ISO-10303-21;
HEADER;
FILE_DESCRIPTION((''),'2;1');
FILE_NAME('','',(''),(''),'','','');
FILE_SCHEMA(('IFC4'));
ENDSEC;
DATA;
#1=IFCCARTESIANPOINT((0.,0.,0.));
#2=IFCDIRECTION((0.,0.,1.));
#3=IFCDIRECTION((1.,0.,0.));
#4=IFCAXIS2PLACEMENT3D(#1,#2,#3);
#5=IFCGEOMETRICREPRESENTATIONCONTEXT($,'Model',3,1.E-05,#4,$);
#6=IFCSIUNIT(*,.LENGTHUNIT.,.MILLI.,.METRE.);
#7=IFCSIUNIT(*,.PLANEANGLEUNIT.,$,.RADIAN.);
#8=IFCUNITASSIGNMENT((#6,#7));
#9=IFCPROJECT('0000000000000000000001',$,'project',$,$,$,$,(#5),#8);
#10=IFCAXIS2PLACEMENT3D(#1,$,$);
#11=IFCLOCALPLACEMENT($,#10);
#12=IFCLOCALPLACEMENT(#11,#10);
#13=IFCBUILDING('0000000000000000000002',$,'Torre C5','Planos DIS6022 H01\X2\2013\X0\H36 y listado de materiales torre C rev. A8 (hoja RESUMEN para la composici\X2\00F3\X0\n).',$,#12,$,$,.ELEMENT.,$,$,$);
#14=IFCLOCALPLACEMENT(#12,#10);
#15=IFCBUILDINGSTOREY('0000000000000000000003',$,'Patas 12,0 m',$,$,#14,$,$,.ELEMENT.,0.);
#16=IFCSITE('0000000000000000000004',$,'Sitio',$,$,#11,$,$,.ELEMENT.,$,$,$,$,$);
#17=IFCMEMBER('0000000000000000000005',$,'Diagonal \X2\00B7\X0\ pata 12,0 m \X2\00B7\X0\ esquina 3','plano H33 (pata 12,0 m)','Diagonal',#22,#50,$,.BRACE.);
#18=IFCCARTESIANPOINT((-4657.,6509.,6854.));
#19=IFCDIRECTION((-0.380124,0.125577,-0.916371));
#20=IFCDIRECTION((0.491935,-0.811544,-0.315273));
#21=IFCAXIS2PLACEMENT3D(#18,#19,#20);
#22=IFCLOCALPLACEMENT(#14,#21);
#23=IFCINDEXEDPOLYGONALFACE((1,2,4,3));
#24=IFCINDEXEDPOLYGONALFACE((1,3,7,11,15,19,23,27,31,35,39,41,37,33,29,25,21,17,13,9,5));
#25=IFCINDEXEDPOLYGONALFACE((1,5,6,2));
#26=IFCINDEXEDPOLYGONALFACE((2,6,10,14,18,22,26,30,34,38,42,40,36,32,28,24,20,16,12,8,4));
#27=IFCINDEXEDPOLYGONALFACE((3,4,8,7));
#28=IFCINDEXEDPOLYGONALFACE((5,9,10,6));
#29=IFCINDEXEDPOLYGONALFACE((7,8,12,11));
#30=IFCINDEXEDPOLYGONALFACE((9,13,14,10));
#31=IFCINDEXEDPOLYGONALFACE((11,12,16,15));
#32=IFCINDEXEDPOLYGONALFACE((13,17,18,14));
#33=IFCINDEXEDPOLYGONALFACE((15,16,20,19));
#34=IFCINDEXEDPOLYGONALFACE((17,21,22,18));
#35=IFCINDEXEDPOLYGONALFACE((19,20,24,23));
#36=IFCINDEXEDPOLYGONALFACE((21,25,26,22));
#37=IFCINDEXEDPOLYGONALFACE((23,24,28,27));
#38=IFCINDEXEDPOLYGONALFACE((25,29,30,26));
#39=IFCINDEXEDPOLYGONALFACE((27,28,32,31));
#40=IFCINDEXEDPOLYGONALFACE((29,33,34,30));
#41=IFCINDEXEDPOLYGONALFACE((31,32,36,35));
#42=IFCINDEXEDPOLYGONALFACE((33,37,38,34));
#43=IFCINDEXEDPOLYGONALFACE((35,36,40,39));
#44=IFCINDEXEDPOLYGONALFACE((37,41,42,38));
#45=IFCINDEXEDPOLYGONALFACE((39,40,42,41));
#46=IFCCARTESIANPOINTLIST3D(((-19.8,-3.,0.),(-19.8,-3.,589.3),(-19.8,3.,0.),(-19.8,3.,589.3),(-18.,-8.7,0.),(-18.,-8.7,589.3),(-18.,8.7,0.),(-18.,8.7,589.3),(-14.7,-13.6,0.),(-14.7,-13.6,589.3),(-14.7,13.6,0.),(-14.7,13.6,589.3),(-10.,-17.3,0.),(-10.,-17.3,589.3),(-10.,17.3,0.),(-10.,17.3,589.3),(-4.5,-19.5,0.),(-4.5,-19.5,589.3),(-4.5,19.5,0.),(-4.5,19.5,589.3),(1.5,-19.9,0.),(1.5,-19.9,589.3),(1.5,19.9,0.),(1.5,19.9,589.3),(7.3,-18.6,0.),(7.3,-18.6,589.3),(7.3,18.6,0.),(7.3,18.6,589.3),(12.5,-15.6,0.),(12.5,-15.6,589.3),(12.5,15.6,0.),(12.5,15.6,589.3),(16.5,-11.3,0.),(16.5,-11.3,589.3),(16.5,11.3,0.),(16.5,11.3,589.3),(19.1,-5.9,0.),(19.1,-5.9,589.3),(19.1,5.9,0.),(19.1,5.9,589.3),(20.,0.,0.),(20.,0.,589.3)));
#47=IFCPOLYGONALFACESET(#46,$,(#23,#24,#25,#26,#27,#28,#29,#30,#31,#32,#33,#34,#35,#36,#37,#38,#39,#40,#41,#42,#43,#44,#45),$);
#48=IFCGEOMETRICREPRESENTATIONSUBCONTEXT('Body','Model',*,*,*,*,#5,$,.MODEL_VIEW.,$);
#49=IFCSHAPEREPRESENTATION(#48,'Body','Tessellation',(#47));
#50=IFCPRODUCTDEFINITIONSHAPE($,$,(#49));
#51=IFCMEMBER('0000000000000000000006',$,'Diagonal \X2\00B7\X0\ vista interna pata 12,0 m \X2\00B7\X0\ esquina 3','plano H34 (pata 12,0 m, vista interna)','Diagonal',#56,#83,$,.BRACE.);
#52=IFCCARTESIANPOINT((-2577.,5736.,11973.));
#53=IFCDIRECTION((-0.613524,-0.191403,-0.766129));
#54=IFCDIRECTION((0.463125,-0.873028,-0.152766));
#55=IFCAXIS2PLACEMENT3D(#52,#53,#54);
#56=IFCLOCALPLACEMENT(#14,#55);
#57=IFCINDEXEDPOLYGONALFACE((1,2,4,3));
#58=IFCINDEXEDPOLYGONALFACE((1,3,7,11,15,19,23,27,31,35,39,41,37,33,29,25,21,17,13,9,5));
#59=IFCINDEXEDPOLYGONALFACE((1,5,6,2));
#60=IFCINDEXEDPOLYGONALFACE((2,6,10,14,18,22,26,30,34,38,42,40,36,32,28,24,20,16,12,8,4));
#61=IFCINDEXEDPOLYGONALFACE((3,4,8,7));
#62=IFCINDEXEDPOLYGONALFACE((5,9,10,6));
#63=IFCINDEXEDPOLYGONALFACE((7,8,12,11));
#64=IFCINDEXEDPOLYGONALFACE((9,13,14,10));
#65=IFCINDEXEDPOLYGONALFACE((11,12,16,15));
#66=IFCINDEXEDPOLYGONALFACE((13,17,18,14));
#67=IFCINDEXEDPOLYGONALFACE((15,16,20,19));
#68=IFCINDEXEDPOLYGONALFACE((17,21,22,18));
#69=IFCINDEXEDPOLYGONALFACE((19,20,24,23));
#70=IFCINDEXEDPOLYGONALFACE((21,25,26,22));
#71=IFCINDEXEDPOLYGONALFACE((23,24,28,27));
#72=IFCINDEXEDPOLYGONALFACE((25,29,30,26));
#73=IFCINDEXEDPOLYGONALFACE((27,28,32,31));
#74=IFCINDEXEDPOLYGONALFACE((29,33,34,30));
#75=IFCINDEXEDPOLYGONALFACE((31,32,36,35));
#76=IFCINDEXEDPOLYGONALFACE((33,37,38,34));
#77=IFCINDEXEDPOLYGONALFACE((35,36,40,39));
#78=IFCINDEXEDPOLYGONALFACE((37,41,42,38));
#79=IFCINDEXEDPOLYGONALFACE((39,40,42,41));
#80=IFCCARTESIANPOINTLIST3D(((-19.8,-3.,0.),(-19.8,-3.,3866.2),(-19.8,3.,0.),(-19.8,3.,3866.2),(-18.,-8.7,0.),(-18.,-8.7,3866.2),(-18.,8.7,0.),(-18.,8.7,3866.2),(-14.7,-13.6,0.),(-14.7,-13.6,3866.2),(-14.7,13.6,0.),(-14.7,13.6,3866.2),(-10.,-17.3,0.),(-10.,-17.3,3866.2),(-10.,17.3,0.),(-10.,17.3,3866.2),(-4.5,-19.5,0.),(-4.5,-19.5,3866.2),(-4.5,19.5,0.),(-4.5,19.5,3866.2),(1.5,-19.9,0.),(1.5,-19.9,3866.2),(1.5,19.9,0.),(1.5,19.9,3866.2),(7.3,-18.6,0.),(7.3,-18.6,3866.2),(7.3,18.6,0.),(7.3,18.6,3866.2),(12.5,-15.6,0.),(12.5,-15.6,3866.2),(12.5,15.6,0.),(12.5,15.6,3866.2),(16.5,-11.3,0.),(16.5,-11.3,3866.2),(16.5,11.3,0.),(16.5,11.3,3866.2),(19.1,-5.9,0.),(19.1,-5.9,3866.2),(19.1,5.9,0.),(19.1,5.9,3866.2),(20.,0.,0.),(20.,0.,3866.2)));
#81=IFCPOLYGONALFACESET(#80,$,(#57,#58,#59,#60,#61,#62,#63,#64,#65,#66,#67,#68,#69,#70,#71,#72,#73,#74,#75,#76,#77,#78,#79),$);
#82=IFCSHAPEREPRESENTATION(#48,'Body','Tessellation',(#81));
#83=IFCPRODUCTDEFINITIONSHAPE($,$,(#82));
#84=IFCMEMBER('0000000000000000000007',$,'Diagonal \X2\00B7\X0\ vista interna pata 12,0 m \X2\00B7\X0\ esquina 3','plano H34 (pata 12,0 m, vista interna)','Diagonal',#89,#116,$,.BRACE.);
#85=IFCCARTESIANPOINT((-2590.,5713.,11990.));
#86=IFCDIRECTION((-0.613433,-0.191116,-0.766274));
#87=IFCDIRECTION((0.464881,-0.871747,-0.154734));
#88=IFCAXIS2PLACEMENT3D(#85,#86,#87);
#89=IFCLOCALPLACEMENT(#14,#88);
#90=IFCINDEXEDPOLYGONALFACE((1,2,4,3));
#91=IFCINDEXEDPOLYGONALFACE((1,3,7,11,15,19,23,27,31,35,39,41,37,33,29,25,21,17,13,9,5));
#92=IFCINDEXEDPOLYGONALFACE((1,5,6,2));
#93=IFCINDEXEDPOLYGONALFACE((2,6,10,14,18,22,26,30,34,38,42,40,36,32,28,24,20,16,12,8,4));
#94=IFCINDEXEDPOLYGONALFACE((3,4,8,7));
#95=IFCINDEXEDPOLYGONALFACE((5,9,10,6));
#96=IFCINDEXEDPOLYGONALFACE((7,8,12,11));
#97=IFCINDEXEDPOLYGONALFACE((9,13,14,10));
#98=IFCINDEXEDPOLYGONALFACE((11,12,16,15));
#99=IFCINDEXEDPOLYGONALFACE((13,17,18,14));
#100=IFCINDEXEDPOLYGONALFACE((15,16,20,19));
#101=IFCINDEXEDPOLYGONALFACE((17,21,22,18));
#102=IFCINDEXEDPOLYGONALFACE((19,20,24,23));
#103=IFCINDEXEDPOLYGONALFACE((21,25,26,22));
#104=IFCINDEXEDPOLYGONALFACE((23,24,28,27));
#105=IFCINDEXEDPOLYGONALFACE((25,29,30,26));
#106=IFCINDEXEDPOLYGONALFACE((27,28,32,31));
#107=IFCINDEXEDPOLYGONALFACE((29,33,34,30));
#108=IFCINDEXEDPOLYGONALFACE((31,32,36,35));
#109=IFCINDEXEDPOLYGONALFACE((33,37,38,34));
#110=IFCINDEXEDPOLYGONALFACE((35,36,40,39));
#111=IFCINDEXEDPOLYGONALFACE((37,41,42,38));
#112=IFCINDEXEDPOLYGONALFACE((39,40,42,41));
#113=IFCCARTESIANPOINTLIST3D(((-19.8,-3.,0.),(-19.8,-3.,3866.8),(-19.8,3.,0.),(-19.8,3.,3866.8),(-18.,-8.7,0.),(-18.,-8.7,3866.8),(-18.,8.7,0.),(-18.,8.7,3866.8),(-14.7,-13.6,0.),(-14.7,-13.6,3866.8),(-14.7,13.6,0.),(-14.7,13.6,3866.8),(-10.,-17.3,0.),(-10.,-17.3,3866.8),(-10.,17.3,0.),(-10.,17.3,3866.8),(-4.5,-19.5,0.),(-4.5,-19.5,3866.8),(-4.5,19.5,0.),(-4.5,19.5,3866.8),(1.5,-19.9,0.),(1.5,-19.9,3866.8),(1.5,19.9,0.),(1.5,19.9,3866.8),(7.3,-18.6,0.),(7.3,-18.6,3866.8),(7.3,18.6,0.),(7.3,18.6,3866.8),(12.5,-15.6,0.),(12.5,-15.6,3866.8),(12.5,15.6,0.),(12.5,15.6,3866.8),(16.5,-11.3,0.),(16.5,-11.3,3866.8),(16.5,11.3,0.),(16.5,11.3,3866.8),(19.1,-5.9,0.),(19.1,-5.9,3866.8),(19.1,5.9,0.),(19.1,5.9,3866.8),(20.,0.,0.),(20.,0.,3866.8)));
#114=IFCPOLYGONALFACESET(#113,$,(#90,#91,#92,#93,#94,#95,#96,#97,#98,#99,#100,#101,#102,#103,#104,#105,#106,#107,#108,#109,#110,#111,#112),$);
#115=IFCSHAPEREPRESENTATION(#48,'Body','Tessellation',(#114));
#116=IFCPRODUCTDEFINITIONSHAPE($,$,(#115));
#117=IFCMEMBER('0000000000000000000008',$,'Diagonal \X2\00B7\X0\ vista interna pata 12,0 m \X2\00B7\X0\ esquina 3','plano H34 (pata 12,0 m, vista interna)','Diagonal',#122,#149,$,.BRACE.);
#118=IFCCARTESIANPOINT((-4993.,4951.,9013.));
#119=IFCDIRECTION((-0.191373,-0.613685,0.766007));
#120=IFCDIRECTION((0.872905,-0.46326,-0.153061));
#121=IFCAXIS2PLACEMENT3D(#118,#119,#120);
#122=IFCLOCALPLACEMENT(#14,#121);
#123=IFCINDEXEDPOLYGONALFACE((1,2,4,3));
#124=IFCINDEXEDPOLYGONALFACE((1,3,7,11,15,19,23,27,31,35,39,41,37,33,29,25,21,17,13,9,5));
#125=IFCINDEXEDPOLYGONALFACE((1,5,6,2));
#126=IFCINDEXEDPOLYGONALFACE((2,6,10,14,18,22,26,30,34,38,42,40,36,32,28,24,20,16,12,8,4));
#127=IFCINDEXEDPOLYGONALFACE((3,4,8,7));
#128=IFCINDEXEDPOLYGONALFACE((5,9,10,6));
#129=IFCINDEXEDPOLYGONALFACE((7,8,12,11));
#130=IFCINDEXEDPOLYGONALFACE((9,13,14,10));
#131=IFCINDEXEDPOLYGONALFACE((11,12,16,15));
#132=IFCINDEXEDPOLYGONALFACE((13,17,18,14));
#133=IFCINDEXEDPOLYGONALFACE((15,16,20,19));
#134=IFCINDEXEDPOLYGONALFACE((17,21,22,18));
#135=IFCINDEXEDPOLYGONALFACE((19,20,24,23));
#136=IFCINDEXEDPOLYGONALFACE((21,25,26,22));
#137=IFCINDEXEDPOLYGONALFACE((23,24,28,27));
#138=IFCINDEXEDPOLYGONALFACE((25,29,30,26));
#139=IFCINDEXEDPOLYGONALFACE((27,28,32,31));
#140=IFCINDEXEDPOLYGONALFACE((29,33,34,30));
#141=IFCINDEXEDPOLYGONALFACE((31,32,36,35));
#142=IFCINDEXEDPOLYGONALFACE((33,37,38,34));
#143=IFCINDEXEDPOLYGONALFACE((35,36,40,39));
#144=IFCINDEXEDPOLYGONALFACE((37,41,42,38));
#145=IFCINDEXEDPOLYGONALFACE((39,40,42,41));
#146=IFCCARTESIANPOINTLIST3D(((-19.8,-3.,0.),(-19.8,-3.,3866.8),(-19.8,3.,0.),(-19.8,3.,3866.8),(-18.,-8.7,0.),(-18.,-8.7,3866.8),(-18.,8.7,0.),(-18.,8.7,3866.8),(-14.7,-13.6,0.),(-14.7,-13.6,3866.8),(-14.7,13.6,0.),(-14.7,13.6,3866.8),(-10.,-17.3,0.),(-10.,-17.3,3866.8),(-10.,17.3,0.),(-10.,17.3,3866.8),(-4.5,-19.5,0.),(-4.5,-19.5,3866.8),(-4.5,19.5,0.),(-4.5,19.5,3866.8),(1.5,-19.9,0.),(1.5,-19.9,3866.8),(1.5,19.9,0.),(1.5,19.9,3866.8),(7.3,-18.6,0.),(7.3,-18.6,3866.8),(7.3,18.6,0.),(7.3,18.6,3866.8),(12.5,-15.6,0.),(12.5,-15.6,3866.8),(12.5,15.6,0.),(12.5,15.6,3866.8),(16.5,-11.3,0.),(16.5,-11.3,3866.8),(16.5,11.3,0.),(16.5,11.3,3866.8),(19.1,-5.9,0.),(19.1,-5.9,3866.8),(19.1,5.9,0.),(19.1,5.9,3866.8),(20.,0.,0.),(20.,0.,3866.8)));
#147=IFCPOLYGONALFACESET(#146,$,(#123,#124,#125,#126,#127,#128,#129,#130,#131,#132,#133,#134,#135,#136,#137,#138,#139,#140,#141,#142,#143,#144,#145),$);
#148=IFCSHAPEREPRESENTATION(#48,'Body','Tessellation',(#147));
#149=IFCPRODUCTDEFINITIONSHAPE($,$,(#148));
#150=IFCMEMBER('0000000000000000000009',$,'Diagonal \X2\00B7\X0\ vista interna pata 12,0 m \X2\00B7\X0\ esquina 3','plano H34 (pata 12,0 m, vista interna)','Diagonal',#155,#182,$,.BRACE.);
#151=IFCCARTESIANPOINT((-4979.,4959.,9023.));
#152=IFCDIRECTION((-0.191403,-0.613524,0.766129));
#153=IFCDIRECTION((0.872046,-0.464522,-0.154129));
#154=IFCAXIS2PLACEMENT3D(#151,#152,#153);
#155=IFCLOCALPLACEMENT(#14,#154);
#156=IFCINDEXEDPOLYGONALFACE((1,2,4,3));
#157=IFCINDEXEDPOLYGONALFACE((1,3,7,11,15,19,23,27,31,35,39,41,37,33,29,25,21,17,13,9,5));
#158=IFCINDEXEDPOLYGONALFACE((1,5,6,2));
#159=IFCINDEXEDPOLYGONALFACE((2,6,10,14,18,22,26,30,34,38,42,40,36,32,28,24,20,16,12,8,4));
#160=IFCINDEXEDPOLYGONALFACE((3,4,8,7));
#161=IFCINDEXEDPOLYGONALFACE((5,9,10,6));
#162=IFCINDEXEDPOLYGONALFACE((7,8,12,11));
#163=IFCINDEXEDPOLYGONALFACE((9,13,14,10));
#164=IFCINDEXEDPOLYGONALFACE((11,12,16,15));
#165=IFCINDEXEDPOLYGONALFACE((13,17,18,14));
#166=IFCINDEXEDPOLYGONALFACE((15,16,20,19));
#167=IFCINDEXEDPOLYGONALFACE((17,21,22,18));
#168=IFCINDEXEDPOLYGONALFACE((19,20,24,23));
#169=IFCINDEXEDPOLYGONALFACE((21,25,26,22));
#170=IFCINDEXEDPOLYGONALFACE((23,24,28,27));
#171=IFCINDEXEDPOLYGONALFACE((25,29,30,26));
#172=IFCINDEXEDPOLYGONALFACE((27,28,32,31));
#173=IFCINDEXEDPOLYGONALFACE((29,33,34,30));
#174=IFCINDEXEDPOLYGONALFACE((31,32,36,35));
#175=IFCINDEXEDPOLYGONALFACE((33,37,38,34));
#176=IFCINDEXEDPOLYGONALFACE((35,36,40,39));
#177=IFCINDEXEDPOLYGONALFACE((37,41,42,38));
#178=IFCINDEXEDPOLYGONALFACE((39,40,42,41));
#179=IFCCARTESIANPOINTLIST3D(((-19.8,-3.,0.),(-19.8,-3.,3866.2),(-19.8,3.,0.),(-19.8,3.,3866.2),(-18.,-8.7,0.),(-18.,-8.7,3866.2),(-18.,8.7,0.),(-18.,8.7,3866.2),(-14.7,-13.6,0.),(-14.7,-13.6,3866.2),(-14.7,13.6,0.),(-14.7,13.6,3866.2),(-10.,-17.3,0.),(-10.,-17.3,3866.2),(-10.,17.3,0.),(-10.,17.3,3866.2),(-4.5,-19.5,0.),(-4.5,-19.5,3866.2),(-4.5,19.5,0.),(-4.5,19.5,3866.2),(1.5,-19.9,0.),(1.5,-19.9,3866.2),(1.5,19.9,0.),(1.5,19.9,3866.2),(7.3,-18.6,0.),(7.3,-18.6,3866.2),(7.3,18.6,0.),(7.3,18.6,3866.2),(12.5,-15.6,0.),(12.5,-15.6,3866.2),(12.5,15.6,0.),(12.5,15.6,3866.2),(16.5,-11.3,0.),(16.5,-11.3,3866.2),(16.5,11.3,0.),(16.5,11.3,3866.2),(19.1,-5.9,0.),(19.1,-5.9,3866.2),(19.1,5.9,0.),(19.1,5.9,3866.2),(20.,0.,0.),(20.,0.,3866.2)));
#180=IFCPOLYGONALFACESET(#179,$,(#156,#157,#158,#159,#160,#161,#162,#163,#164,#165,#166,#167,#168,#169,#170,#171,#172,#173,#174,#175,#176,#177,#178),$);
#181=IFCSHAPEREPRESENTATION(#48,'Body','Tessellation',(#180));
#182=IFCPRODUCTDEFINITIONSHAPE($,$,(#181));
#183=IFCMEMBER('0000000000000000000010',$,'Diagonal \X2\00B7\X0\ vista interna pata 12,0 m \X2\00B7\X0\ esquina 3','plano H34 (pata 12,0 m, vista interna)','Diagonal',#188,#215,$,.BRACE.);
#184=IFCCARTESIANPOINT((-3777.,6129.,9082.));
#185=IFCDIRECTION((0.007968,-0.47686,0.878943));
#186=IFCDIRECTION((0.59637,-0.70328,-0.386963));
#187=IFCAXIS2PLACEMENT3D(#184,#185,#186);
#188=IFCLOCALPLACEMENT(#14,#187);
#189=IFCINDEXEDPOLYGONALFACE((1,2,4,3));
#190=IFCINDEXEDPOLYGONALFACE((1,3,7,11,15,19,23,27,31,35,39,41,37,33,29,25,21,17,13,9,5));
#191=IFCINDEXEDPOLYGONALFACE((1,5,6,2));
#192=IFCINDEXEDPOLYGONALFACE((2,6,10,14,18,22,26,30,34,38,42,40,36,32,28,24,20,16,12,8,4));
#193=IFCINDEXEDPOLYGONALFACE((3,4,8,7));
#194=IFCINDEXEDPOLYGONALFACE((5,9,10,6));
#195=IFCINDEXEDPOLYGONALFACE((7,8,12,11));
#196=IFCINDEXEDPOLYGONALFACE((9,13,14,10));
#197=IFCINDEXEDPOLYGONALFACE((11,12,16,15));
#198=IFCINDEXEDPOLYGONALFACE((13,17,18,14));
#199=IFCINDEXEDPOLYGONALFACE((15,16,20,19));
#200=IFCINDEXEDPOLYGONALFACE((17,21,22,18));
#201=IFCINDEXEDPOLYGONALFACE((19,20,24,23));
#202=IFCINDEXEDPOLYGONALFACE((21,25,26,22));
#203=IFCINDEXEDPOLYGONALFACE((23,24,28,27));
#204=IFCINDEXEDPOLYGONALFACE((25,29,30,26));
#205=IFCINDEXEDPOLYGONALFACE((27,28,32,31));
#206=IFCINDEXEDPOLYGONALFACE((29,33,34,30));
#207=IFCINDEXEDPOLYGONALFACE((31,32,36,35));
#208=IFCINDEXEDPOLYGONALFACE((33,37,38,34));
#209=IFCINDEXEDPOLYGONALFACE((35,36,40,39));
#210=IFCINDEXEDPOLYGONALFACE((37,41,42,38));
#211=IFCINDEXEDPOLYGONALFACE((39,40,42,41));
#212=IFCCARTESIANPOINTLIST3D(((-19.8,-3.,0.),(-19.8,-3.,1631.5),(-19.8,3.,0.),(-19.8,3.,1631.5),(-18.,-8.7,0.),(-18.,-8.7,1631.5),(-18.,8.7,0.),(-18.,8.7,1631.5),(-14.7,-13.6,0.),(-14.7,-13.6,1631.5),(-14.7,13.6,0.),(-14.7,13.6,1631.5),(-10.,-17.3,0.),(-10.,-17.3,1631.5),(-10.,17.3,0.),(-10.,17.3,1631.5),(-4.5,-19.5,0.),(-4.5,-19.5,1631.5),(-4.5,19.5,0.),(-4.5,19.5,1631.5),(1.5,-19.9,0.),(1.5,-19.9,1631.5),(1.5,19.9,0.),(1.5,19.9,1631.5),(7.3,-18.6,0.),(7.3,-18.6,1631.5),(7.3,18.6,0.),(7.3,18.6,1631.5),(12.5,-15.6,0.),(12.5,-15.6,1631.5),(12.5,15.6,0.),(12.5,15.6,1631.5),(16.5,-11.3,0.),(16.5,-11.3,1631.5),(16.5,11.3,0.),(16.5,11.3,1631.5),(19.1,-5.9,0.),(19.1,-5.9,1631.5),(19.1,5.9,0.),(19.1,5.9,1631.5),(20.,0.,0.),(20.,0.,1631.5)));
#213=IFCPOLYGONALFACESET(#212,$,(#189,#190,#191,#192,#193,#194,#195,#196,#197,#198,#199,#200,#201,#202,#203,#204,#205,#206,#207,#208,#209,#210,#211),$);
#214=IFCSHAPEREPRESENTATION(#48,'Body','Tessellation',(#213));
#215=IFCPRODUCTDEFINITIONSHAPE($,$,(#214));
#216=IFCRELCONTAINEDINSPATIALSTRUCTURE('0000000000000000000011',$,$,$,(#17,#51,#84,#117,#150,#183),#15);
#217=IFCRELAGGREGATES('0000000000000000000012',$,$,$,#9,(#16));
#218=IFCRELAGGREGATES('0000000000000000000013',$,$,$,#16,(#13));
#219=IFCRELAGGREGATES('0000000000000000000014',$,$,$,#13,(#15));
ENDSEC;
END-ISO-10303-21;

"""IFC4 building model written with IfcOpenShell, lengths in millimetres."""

from ifc_helpers import new_model, si_unit, frame, origin, origin_with_axes, place, context, subcontext, project, spatial, circle, extrude, element, save


model = new_model("IFC4")

# Units and contexts
model_context = context("Model", 3, precision=1e-05, world=origin_with_axes())
body_context = subcontext(model_context, "Body", "Model", "MODEL_VIEW")
ifc_project = project(units=[si_unit("LENGTHUNIT", "METRE", prefix="MILLI"), si_unit("PLANEANGLEUNIT", "RADIAN")], contexts=[model_context])

# Site, building, storey
site_placement = place(None, origin())
site = spatial("IfcSite", under=ifc_project, at=site_placement, Name="Sitio", CompositionType="ELEMENT")
building_placement = place(site_placement, origin())
building = spatial("IfcBuilding", under=site, at=building_placement, Name="Torre C5", Description="Planos DIS6022 H01–H36 y listado de materiales torre C rev. A8 (hoja RESUMEN para la composición).", CompositionType="ELEMENT")
storey_placement = place(building_placement, origin())
storey = spatial("IfcBuildingStorey", under=building, at=storey_placement, Name="Patas 12,0 m", CompositionType="ELEMENT", Elevation=0.0)

# Members
member_1_placement = place(storey_placement, frame((-4657.0, 6509.0, 6854.0), z_axis=(-0.380124, 0.125577, -0.916371), x_axis=(0.491935, -0.811544, -0.315273)))
element("IfcMember", 1, at=member_1_placement, inside=storey, Name="Diagonal · pata 12,0 m · esquina 3", Description="plano H33 (pata 12,0 m)", ObjectType="Diagonal", PredefinedType="BRACE", context=body_context, shape_type="SweptSolid", body=[
    extrude(circle(Radius=20.0), None, (0.0, 0.0, 1.0), 589.3),
])
member_2_placement = place(storey_placement, frame((-2577.0, 5736.0, 11973.0), z_axis=(-0.613524, -0.191403, -0.766129), x_axis=(0.463125, -0.873028, -0.152766)))
element("IfcMember", 2, at=member_2_placement, inside=storey, Name="Diagonal · vista interna pata 12,0 m · esquina 3", Description="plano H34 (pata 12,0 m, vista interna)", ObjectType="Diagonal", PredefinedType="BRACE", context=body_context, shape_type="SweptSolid", body=[
    extrude(circle(Radius=20.0), None, (0.0, 0.0, 1.0), 3866.2),
])
member_3_placement = place(storey_placement, frame((-2590.0, 5713.0, 11990.0), z_axis=(-0.613433, -0.191116, -0.766274), x_axis=(0.464881, -0.871747, -0.154734)))
element("IfcMember", 3, at=member_3_placement, inside=storey, Name="Diagonal · vista interna pata 12,0 m · esquina 3", Description="plano H34 (pata 12,0 m, vista interna)", ObjectType="Diagonal", PredefinedType="BRACE", context=body_context, shape_type="SweptSolid", body=[
    extrude(circle(Radius=20.0), None, (0.0, 0.0, 1.0), 3866.8),
])
member_4_placement = place(storey_placement, frame((-4993.0, 4951.0, 9013.0), z_axis=(-0.191373, -0.613685, 0.766007), x_axis=(0.872905, -0.46326, -0.153061)))
element("IfcMember", 4, at=member_4_placement, inside=storey, Name="Diagonal · vista interna pata 12,0 m · esquina 3", Description="plano H34 (pata 12,0 m, vista interna)", ObjectType="Diagonal", PredefinedType="BRACE", context=body_context, shape_type="SweptSolid", body=[
    extrude(circle(Radius=20.0), None, (0.0, 0.0, 1.0), 3866.8),
])
member_5_placement = place(storey_placement, frame((-4979.0, 4959.0, 9023.0), z_axis=(-0.191403, -0.613524, 0.766129), x_axis=(0.872046, -0.464522, -0.154129)))
element("IfcMember", 5, at=member_5_placement, inside=storey, Name="Diagonal · vista interna pata 12,0 m · esquina 3", Description="plano H34 (pata 12,0 m, vista interna)", ObjectType="Diagonal", PredefinedType="BRACE", context=body_context, shape_type="SweptSolid", body=[
    extrude(circle(Radius=20.0), None, (0.0, 0.0, 1.0), 3866.2),
])
member_6_placement = place(storey_placement, frame((-3777.0, 6129.0, 9082.0), z_axis=(0.007968, -0.47686, 0.878943), x_axis=(0.59637, -0.70328, -0.386963)))
element("IfcMember", 6, at=member_6_placement, inside=storey, Name="Diagonal · vista interna pata 12,0 m · esquina 3", Description="plano H34 (pata 12,0 m, vista interna)", ObjectType="Diagonal", PredefinedType="BRACE", context=body_context, shape_type="SweptSolid", body=[
    extrude(circle(Radius=20.0), None, (0.0, 0.0, 1.0), 1631.5),
])

save(model, "model.ifc")
